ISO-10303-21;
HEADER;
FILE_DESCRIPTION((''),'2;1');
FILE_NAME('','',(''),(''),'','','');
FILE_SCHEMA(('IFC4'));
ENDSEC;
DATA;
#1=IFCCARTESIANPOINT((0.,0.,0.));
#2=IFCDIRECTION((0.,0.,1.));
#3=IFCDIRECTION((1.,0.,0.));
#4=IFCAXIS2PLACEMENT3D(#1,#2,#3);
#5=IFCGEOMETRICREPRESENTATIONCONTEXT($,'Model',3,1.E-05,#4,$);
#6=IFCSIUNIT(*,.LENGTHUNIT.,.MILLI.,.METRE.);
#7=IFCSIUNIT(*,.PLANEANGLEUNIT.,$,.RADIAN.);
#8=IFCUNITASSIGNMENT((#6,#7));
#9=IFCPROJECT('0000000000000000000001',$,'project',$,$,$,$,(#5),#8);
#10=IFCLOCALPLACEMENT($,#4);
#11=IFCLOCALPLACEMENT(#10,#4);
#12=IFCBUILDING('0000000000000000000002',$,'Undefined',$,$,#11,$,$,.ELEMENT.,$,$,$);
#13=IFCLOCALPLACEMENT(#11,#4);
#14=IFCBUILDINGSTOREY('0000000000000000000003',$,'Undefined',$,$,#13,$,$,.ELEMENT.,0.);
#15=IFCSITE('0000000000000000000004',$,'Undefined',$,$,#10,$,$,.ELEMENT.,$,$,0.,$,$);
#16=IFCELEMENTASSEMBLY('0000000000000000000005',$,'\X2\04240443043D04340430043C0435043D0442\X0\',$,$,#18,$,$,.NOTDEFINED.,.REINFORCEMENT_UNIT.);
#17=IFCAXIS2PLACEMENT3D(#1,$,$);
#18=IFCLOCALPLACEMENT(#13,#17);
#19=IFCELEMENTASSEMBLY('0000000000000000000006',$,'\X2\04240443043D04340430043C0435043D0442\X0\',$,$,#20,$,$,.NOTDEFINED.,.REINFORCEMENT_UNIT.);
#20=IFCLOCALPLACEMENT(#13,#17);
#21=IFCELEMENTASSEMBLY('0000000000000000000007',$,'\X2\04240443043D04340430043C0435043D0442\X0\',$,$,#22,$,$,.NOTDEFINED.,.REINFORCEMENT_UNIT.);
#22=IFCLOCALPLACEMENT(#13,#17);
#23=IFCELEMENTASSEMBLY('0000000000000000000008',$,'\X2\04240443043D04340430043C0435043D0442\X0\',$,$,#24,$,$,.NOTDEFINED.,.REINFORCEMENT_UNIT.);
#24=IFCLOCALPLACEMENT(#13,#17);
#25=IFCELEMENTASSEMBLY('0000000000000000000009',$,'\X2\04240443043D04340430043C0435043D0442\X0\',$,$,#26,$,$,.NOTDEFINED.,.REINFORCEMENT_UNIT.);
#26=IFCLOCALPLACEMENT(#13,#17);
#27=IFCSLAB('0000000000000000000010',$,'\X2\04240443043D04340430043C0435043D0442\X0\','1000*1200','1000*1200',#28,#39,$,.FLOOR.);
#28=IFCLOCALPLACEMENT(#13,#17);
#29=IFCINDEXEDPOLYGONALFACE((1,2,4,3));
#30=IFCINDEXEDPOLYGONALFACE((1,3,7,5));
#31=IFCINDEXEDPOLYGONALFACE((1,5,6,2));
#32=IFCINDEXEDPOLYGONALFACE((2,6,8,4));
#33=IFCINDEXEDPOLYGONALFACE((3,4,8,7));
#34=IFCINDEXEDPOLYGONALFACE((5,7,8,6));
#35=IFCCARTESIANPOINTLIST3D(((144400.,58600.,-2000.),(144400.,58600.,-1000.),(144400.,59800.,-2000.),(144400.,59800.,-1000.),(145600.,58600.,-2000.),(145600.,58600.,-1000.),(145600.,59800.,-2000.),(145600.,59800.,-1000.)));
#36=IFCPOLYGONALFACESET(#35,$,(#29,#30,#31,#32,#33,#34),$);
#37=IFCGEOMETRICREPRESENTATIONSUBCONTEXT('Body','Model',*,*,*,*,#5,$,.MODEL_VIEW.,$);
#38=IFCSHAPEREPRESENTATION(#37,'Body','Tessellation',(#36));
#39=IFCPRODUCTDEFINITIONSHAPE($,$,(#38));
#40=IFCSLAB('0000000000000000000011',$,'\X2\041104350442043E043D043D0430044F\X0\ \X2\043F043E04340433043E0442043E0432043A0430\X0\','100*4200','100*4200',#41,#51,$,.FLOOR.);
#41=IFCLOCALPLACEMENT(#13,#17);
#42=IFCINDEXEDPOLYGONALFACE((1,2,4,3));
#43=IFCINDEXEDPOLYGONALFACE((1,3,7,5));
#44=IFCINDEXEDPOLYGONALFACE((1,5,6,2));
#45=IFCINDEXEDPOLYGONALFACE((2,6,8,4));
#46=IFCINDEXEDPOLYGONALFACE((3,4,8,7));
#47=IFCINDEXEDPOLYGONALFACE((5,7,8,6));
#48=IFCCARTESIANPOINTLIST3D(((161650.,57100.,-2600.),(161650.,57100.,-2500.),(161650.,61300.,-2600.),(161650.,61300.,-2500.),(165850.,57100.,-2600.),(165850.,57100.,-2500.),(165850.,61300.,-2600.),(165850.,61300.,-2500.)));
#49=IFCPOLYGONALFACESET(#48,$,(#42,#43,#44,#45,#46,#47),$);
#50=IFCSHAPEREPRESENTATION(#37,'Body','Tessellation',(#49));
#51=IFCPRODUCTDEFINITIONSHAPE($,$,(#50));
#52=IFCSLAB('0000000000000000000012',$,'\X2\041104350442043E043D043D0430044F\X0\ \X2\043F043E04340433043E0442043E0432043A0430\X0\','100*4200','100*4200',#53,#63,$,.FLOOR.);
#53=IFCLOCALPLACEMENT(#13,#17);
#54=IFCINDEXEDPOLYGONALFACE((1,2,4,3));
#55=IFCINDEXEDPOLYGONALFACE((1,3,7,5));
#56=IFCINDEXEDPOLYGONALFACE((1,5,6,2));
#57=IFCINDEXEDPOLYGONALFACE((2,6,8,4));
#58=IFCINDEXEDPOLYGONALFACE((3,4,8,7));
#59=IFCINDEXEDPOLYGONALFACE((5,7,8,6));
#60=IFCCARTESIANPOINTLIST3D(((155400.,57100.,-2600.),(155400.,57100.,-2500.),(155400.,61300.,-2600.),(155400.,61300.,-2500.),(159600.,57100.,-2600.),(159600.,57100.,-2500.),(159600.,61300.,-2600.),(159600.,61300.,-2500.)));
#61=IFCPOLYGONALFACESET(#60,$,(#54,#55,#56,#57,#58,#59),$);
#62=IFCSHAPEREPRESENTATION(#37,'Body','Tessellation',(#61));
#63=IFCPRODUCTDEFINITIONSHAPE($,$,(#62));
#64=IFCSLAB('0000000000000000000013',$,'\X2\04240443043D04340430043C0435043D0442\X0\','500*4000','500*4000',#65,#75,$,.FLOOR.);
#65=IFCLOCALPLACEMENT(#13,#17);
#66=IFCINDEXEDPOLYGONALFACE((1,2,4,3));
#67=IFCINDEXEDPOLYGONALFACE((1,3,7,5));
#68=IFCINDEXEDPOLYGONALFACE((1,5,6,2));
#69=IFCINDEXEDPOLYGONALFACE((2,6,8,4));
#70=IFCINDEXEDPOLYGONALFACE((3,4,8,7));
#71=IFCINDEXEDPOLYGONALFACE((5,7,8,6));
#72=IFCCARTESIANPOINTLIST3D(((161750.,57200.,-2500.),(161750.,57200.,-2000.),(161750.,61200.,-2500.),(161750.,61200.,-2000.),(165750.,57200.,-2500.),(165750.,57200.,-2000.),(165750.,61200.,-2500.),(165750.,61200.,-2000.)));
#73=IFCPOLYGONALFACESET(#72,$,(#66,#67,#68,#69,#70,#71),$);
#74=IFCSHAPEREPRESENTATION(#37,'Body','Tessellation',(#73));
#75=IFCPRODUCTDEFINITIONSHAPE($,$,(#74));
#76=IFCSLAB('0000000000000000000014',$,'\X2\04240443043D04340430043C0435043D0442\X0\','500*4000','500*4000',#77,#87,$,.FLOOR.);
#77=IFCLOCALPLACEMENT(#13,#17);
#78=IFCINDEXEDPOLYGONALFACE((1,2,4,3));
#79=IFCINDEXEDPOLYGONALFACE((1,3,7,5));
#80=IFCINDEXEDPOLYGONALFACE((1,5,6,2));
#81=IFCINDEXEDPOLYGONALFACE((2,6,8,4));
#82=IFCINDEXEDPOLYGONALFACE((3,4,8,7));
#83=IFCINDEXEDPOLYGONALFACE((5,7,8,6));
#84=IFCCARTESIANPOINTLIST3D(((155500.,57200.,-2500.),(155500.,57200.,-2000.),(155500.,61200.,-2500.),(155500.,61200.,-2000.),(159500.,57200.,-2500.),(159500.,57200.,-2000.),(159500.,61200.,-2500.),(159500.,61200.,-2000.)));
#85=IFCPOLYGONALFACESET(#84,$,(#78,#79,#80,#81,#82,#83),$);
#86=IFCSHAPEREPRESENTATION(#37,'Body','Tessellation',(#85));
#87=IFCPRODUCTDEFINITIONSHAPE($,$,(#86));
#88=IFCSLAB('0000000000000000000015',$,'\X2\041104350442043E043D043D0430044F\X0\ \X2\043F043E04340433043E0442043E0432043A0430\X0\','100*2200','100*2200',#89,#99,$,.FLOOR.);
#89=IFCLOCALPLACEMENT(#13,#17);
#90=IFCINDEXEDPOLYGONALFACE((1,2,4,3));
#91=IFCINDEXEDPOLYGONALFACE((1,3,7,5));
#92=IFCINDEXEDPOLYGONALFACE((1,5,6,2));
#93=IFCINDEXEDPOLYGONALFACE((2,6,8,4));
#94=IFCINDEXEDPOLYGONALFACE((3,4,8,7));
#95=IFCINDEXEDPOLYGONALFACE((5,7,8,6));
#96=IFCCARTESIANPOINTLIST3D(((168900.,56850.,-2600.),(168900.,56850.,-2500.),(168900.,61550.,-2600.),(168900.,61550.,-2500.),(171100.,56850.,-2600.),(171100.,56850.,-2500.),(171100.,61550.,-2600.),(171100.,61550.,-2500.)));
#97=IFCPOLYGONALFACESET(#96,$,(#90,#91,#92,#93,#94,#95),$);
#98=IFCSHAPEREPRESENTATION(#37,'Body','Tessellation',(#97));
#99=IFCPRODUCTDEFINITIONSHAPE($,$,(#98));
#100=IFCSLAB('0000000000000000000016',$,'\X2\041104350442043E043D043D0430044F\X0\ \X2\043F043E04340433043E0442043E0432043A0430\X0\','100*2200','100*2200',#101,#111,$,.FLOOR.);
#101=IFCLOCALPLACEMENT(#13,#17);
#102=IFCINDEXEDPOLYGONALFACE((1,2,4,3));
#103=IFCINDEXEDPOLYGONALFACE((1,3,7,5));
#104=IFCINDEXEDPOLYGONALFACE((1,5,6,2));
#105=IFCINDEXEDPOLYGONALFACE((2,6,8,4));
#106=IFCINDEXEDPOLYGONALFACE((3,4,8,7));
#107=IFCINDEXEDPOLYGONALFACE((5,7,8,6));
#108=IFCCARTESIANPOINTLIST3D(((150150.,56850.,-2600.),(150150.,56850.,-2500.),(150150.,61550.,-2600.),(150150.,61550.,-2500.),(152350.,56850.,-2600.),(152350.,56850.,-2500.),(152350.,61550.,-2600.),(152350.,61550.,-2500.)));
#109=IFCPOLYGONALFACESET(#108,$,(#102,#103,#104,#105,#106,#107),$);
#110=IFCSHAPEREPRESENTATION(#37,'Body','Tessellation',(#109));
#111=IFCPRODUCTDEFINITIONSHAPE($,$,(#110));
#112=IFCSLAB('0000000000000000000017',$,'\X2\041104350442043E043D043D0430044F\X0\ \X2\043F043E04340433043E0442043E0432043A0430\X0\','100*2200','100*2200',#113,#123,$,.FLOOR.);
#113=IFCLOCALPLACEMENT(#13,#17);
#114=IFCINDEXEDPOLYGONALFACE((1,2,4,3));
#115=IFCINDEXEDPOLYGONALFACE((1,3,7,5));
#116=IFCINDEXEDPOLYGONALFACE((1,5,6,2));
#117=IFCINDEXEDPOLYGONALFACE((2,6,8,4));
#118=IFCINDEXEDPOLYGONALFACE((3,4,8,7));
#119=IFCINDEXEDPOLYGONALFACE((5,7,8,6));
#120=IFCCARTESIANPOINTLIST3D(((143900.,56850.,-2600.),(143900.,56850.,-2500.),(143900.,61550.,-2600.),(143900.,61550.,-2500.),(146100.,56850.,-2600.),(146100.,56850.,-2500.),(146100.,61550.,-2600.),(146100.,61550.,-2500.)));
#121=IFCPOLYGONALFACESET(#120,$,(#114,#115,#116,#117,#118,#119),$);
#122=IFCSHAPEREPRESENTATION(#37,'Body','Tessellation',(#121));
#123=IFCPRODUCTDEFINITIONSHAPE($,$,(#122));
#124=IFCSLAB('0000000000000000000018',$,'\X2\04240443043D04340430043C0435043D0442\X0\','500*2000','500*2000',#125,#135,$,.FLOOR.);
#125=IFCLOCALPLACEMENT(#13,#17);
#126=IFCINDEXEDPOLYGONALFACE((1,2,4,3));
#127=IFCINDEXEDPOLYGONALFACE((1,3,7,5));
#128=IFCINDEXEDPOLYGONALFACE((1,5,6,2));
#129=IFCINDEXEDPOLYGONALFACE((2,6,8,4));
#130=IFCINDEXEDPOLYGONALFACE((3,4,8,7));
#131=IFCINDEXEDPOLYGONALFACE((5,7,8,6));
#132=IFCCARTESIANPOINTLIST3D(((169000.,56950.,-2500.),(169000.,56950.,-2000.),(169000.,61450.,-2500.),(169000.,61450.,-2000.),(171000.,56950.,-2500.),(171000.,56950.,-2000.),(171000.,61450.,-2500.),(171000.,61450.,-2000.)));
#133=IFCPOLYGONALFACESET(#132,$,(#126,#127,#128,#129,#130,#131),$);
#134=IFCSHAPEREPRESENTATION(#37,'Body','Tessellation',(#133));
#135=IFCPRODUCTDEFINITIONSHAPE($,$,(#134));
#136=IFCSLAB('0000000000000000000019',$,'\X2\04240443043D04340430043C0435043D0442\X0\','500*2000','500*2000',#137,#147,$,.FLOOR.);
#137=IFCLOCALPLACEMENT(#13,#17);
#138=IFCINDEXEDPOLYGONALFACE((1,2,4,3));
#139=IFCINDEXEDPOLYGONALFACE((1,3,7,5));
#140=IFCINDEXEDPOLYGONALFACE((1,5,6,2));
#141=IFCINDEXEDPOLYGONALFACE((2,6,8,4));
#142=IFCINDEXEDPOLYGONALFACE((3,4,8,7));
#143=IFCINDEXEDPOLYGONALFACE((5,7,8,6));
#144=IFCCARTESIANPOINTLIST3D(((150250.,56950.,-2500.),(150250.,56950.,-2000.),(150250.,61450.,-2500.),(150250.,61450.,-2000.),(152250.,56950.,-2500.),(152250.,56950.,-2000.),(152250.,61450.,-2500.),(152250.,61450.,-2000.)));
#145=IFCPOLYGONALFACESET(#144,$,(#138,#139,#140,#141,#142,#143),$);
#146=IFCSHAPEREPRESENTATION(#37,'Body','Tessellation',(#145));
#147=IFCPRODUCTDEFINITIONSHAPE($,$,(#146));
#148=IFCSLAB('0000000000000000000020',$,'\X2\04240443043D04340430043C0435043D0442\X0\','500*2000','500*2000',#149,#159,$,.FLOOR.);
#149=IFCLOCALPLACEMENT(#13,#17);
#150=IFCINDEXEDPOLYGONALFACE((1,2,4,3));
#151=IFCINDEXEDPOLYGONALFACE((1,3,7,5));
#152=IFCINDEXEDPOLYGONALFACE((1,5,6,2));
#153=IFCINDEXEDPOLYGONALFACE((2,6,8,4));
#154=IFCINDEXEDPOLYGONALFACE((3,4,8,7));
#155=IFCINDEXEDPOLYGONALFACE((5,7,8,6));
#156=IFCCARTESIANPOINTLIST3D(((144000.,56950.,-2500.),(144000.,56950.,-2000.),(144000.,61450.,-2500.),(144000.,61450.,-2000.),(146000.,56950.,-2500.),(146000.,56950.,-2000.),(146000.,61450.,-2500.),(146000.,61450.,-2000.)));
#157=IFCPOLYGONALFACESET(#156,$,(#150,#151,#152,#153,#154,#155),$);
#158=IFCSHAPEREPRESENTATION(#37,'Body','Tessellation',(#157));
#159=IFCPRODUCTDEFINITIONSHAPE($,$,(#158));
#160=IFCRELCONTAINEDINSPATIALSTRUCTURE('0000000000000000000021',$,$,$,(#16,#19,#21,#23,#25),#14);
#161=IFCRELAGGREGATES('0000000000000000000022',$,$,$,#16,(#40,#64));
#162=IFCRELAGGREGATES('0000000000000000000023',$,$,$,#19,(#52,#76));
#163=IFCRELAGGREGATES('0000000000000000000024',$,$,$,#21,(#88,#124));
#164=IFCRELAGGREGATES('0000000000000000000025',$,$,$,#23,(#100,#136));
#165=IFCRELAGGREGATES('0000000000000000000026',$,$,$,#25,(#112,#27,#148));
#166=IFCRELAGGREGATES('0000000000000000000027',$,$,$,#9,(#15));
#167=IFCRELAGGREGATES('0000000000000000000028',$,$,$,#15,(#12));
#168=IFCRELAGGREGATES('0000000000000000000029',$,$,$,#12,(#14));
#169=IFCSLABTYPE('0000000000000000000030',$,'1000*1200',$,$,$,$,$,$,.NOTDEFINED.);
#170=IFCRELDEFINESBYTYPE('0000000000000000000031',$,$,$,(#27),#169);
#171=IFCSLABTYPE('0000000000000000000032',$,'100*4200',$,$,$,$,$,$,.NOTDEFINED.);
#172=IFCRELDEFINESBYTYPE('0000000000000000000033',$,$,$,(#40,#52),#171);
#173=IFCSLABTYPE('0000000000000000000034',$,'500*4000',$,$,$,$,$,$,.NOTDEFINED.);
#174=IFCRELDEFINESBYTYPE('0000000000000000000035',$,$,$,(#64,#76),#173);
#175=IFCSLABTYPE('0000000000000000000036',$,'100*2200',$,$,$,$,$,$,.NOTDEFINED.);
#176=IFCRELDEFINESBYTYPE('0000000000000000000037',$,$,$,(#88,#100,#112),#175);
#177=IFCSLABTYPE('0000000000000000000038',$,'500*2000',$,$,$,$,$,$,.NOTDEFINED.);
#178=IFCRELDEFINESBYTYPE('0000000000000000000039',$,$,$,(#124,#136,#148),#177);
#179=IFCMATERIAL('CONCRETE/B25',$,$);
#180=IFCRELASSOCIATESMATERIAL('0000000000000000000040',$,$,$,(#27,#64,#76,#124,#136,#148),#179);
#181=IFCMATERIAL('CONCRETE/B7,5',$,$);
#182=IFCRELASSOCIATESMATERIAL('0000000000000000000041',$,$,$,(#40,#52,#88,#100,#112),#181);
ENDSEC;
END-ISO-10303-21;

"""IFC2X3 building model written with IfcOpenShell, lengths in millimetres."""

from ifc_helpers import new_model, si_unit, frame, origin_with_axes, place, context, subcontext, project, spatial, polyline, outline, extrude, material, type_object, element, aggregate, save


model = new_model("IFC2X3")

# Units and contexts
model_context = context("Model", 3, precision=1e-05, world=origin_with_axes())
body_context = subcontext(model_context, "Body", "Model", "MODEL_VIEW")
ifc_project = project(units=[si_unit("LENGTHUNIT", "METRE", prefix="MILLI"), si_unit("PLANEANGLEUNIT", "RADIAN")], contexts=[model_context])

# Site, building, storey
site_placement = place(None, origin_with_axes())
site = spatial("IfcSite", under=ifc_project, at=site_placement, Name="Undefined", CompositionType="ELEMENT", RefElevation=0.0)
building_placement = place(site_placement, origin_with_axes())
building = spatial("IfcBuilding", under=site, at=building_placement, Name="Undefined", CompositionType="ELEMENT")
storey_placement = place(building_placement, origin_with_axes())
storey = spatial("IfcBuildingStorey", under=building, at=storey_placement, Name="Undefined", CompositionType="ELEMENT", Elevation=0.0)

# Element assemblies
assembly_1_placement = place(storey_placement, origin_with_axes())
assembly_1 = element("IfcElementAssembly", 1, at=assembly_1_placement, inside=storey, Name="Фундамент", AssemblyPlace="NOTDEFINED", PredefinedType="REINFORCEMENT_UNIT")
ifc_material_1 = material(Name="CONCRETE/B25")
assembly_2_placement = place(storey_placement, origin_with_axes())
assembly_2 = element("IfcElementAssembly", 2, at=assembly_2_placement, inside=storey, Name="Фундамент", AssemblyPlace="NOTDEFINED", PredefinedType="REINFORCEMENT_UNIT")
assembly_3_placement = place(storey_placement, origin_with_axes())
assembly_3 = element("IfcElementAssembly", 3, at=assembly_3_placement, inside=storey, Name="Фундамент", AssemblyPlace="NOTDEFINED", PredefinedType="REINFORCEMENT_UNIT")
assembly_4_placement = place(storey_placement, origin_with_axes())
assembly_4 = element("IfcElementAssembly", 4, at=assembly_4_placement, inside=storey, Name="Фундамент", AssemblyPlace="NOTDEFINED", PredefinedType="REINFORCEMENT_UNIT")
assembly_5_placement = place(storey_placement, origin_with_axes())
assembly_5 = element("IfcElementAssembly", 5, at=assembly_5_placement, inside=storey, Name="Фундамент", AssemblyPlace="NOTDEFINED", PredefinedType="REINFORCEMENT_UNIT")

# Slabs
slab_type_1 = type_object("IfcSlabType", Name="1000*1200", PredefinedType="NOTDEFINED")
slab_1_placement = place(assembly_5_placement, frame((144400.0, 59800.0, -1500.0), z_axis=(0.0, 0.0, 1.0), x_axis=(0.0, -1.0, 0.0)))
slab_1 = element("IfcSlab", 6, at=slab_1_placement, type_object=slab_type_1, material=ifc_material_1, Name="Фундамент", Description="1000*1200", ObjectType="1000*1200", PredefinedType="FLOOR", context=body_context, shape_type="SweptSolid", body=[
    extrude(outline(polyline([(0.0, 0.0), (1200.0, 0.0), (1200.0, 1200.0), (0.0, 1200.0), (0.0, 0.0)])), frame((0.0, 0.0, -500.0), z_axis=(0.0, 0.0, 1.0), x_axis=(1.0, 0.0, 0.0)), (0.0, 0.0, 1.0), 1000.0),
])
ifc_material_2 = material(Name="CONCRETE/B7,5")
slab_type_2 = type_object("IfcSlabType", Name="100*4200", PredefinedType="NOTDEFINED")
slab_2_placement = place(assembly_1_placement, frame((161650.0, 61300.0, -2550.0), z_axis=(0.0, 0.0, 1.0), x_axis=(0.0, -1.0, 0.0)))
slab_2 = element("IfcSlab", 7, at=slab_2_placement, type_object=slab_type_2, material=ifc_material_2, Name="Бетонная подготовка", Description="100*4200", ObjectType="100*4200", PredefinedType="FLOOR", context=body_context, shape_type="SweptSolid", body=[
    extrude(outline(polyline([(0.0, 0.0), (4200.0, 0.0), (4200.0, 4200.0), (0.0, 4200.0), (0.0, 0.0)])), frame((0.0, 0.0, -50.0), z_axis=(0.0, 0.0, 1.0), x_axis=(1.0, 0.0, 0.0)), (0.0, 0.0, 1.0), 100.0),
])
slab_3_placement = place(assembly_2_placement, frame((155400.0, 61300.0, -2550.0), z_axis=(0.0, 0.0, 1.0), x_axis=(0.0, -1.0, 0.0)))
slab_3 = element("IfcSlab", 8, at=slab_3_placement, type_object=slab_type_2, material=ifc_material_2, Name="Бетонная подготовка", Description="100*4200", ObjectType="100*4200", PredefinedType="FLOOR", context=body_context, shape_type="SweptSolid", body=[
    extrude(outline(polyline([(0.0, 0.0), (4200.0, 0.0), (4200.0, 4200.0), (0.0, 4200.0), (0.0, 0.0)])), frame((0.0, 0.0, -50.0), z_axis=(0.0, 0.0, 1.0), x_axis=(1.0, 0.0, 0.0)), (0.0, 0.0, 1.0), 100.0),
])
slab_type_3 = type_object("IfcSlabType", Name="500*4000", PredefinedType="NOTDEFINED")
slab_4_placement = place(assembly_1_placement, frame((161750.0, 61200.0, -2250.0), z_axis=(0.0, 0.0, 1.0), x_axis=(0.0, -1.0, 0.0)))
slab_4 = element("IfcSlab", 9, at=slab_4_placement, type_object=slab_type_3, material=ifc_material_1, Name="Фундамент", Description="500*4000", ObjectType="500*4000", PredefinedType="FLOOR", context=body_context, shape_type="SweptSolid", body=[
    extrude(outline(polyline([(0.0, 0.0), (4000.0, 0.0), (4000.0, 4000.0), (0.0, 4000.0), (0.0, 0.0)])), frame((0.0, 0.0, -250.0), z_axis=(0.0, 0.0, 1.0), x_axis=(1.0, 0.0, 0.0)), (0.0, 0.0, 1.0), 500.0),
])
aggregate(assembly_1, [slab_2, slab_4])
slab_5_placement = place(assembly_2_placement, frame((155500.0, 61200.0, -2250.0), z_axis=(0.0, 0.0, 1.0), x_axis=(0.0, -1.0, 0.0)))
slab_5 = element("IfcSlab", 10, at=slab_5_placement, type_object=slab_type_3, material=ifc_material_1, Name="Фундамент", Description="500*4000", ObjectType="500*4000", PredefinedType="FLOOR", context=body_context, shape_type="SweptSolid", body=[
    extrude(outline(polyline([(0.0, 0.0), (4000.0, 0.0), (4000.0, 4000.0), (0.0, 4000.0), (0.0, 0.0)])), frame((0.0, 0.0, -250.0), z_axis=(0.0, 0.0, 1.0), x_axis=(1.0, 0.0, 0.0)), (0.0, 0.0, 1.0), 500.0),
])
aggregate(assembly_2, [slab_3, slab_5])
slab_type_4 = type_object("IfcSlabType", Name="100*2200", PredefinedType="NOTDEFINED")
slab_6_placement = place(assembly_3_placement, frame((168900.0, 61550.0, -2550.0), z_axis=(0.0, 0.0, 1.0), x_axis=(0.0, -1.0, 0.0)))
slab_6 = element("IfcSlab", 11, at=slab_6_placement, type_object=slab_type_4, material=ifc_material_2, Name="Бетонная подготовка", Description="100*2200", ObjectType="100*2200", PredefinedType="FLOOR", context=body_context, shape_type="SweptSolid", body=[
    extrude(outline(polyline([(0.0, 0.0), (4700.0, 0.0), (4700.0, 2200.0), (0.0, 2200.0), (0.0, 0.0)])), frame((0.0, 0.0, -50.0), z_axis=(0.0, 0.0, 1.0), x_axis=(1.0, 0.0, 0.0)), (0.0, 0.0, 1.0), 100.0),
])
slab_7_placement = place(assembly_4_placement, frame((150150.0, 61550.0, -2550.0), z_axis=(0.0, 0.0, 1.0), x_axis=(0.0, -1.0, 0.0)))
slab_7 = element("IfcSlab", 12, at=slab_7_placement, type_object=slab_type_4, material=ifc_material_2, Name="Бетонная подготовка", Description="100*2200", ObjectType="100*2200", PredefinedType="FLOOR", context=body_context, shape_type="SweptSolid", body=[
    extrude(outline(polyline([(0.0, 0.0), (4700.0, 0.0), (4700.0, 2200.0), (0.0, 2200.0), (0.0, 0.0)])), frame((0.0, 0.0, -50.0), z_axis=(0.0, 0.0, 1.0), x_axis=(1.0, 0.0, 0.0)), (0.0, 0.0, 1.0), 100.0),
])
slab_8_placement = place(assembly_5_placement, frame((143900.0, 61550.0, -2550.0), z_axis=(0.0, 0.0, 1.0), x_axis=(0.0, -1.0, 0.0)))
slab_8 = element("IfcSlab", 13, at=slab_8_placement, type_object=slab_type_4, material=ifc_material_2, Name="Бетонная подготовка", Description="100*2200", ObjectType="100*2200", PredefinedType="FLOOR", context=body_context, shape_type="SweptSolid", body=[
    extrude(outline(polyline([(0.0, 0.0), (4700.0, 0.0), (4700.0, 2200.0), (0.0, 2200.0), (0.0, 0.0)])), frame((0.0, 0.0, -50.0), z_axis=(0.0, 0.0, 1.0), x_axis=(1.0, 0.0, 0.0)), (0.0, 0.0, 1.0), 100.0),
])
slab_type_5 = type_object("IfcSlabType", Name="500*2000", PredefinedType="NOTDEFINED")
slab_9_placement = place(assembly_3_placement, frame((169000.0, 61450.0, -2250.0), z_axis=(0.0, 0.0, 1.0), x_axis=(0.0, -1.0, 0.0)))
slab_9 = element("IfcSlab", 14, at=slab_9_placement, type_object=slab_type_5, material=ifc_material_1, Name="Фундамент", Description="500*2000", ObjectType="500*2000", PredefinedType="FLOOR", context=body_context, shape_type="SweptSolid", body=[
    extrude(outline(polyline([(0.0, 0.0), (4500.0, 0.0), (4500.0, 2000.0), (0.0, 2000.0), (0.0, 0.0)])), frame((0.0, 0.0, -250.0), z_axis=(0.0, 0.0, 1.0), x_axis=(1.0, 0.0, 0.0)), (0.0, 0.0, 1.0), 500.0),
])
aggregate(assembly_3, [slab_6, slab_9])
slab_10_placement = place(assembly_4_placement, frame((150250.0, 61450.0, -2250.0), z_axis=(0.0, 0.0, 1.0), x_axis=(0.0, -1.0, 0.0)))
slab_10 = element("IfcSlab", 15, at=slab_10_placement, type_object=slab_type_5, material=ifc_material_1, Name="Фундамент", Description="500*2000", ObjectType="500*2000", PredefinedType="FLOOR", context=body_context, shape_type="SweptSolid", body=[
    extrude(outline(polyline([(0.0, 0.0), (4500.0, 0.0), (4500.0, 2000.0), (0.0, 2000.0), (0.0, 0.0)])), frame((0.0, 0.0, -250.0), z_axis=(0.0, 0.0, 1.0), x_axis=(1.0, 0.0, 0.0)), (0.0, 0.0, 1.0), 500.0),
])
aggregate(assembly_4, [slab_7, slab_10])
slab_11_placement = place(assembly_5_placement, frame((144000.0, 61450.0, -2250.0), z_axis=(0.0, 0.0, 1.0), x_axis=(0.0, -1.0, 0.0)))
slab_11 = element("IfcSlab", 16, at=slab_11_placement, type_object=slab_type_5, material=ifc_material_1, Name="Фундамент", Description="500*2000", ObjectType="500*2000", PredefinedType="FLOOR", context=body_context, shape_type="SweptSolid", body=[
    extrude(outline(polyline([(0.0, 0.0), (4500.0, 0.0), (4500.0, 2000.0), (0.0, 2000.0), (0.0, 0.0)])), frame((0.0, 0.0, -250.0), z_axis=(0.0, 0.0, 1.0), x_axis=(1.0, 0.0, 0.0)), (0.0, 0.0, 1.0), 500.0),
])
aggregate(assembly_5, [slab_8, slab_1, slab_11])

save(model, "model.ifc")
